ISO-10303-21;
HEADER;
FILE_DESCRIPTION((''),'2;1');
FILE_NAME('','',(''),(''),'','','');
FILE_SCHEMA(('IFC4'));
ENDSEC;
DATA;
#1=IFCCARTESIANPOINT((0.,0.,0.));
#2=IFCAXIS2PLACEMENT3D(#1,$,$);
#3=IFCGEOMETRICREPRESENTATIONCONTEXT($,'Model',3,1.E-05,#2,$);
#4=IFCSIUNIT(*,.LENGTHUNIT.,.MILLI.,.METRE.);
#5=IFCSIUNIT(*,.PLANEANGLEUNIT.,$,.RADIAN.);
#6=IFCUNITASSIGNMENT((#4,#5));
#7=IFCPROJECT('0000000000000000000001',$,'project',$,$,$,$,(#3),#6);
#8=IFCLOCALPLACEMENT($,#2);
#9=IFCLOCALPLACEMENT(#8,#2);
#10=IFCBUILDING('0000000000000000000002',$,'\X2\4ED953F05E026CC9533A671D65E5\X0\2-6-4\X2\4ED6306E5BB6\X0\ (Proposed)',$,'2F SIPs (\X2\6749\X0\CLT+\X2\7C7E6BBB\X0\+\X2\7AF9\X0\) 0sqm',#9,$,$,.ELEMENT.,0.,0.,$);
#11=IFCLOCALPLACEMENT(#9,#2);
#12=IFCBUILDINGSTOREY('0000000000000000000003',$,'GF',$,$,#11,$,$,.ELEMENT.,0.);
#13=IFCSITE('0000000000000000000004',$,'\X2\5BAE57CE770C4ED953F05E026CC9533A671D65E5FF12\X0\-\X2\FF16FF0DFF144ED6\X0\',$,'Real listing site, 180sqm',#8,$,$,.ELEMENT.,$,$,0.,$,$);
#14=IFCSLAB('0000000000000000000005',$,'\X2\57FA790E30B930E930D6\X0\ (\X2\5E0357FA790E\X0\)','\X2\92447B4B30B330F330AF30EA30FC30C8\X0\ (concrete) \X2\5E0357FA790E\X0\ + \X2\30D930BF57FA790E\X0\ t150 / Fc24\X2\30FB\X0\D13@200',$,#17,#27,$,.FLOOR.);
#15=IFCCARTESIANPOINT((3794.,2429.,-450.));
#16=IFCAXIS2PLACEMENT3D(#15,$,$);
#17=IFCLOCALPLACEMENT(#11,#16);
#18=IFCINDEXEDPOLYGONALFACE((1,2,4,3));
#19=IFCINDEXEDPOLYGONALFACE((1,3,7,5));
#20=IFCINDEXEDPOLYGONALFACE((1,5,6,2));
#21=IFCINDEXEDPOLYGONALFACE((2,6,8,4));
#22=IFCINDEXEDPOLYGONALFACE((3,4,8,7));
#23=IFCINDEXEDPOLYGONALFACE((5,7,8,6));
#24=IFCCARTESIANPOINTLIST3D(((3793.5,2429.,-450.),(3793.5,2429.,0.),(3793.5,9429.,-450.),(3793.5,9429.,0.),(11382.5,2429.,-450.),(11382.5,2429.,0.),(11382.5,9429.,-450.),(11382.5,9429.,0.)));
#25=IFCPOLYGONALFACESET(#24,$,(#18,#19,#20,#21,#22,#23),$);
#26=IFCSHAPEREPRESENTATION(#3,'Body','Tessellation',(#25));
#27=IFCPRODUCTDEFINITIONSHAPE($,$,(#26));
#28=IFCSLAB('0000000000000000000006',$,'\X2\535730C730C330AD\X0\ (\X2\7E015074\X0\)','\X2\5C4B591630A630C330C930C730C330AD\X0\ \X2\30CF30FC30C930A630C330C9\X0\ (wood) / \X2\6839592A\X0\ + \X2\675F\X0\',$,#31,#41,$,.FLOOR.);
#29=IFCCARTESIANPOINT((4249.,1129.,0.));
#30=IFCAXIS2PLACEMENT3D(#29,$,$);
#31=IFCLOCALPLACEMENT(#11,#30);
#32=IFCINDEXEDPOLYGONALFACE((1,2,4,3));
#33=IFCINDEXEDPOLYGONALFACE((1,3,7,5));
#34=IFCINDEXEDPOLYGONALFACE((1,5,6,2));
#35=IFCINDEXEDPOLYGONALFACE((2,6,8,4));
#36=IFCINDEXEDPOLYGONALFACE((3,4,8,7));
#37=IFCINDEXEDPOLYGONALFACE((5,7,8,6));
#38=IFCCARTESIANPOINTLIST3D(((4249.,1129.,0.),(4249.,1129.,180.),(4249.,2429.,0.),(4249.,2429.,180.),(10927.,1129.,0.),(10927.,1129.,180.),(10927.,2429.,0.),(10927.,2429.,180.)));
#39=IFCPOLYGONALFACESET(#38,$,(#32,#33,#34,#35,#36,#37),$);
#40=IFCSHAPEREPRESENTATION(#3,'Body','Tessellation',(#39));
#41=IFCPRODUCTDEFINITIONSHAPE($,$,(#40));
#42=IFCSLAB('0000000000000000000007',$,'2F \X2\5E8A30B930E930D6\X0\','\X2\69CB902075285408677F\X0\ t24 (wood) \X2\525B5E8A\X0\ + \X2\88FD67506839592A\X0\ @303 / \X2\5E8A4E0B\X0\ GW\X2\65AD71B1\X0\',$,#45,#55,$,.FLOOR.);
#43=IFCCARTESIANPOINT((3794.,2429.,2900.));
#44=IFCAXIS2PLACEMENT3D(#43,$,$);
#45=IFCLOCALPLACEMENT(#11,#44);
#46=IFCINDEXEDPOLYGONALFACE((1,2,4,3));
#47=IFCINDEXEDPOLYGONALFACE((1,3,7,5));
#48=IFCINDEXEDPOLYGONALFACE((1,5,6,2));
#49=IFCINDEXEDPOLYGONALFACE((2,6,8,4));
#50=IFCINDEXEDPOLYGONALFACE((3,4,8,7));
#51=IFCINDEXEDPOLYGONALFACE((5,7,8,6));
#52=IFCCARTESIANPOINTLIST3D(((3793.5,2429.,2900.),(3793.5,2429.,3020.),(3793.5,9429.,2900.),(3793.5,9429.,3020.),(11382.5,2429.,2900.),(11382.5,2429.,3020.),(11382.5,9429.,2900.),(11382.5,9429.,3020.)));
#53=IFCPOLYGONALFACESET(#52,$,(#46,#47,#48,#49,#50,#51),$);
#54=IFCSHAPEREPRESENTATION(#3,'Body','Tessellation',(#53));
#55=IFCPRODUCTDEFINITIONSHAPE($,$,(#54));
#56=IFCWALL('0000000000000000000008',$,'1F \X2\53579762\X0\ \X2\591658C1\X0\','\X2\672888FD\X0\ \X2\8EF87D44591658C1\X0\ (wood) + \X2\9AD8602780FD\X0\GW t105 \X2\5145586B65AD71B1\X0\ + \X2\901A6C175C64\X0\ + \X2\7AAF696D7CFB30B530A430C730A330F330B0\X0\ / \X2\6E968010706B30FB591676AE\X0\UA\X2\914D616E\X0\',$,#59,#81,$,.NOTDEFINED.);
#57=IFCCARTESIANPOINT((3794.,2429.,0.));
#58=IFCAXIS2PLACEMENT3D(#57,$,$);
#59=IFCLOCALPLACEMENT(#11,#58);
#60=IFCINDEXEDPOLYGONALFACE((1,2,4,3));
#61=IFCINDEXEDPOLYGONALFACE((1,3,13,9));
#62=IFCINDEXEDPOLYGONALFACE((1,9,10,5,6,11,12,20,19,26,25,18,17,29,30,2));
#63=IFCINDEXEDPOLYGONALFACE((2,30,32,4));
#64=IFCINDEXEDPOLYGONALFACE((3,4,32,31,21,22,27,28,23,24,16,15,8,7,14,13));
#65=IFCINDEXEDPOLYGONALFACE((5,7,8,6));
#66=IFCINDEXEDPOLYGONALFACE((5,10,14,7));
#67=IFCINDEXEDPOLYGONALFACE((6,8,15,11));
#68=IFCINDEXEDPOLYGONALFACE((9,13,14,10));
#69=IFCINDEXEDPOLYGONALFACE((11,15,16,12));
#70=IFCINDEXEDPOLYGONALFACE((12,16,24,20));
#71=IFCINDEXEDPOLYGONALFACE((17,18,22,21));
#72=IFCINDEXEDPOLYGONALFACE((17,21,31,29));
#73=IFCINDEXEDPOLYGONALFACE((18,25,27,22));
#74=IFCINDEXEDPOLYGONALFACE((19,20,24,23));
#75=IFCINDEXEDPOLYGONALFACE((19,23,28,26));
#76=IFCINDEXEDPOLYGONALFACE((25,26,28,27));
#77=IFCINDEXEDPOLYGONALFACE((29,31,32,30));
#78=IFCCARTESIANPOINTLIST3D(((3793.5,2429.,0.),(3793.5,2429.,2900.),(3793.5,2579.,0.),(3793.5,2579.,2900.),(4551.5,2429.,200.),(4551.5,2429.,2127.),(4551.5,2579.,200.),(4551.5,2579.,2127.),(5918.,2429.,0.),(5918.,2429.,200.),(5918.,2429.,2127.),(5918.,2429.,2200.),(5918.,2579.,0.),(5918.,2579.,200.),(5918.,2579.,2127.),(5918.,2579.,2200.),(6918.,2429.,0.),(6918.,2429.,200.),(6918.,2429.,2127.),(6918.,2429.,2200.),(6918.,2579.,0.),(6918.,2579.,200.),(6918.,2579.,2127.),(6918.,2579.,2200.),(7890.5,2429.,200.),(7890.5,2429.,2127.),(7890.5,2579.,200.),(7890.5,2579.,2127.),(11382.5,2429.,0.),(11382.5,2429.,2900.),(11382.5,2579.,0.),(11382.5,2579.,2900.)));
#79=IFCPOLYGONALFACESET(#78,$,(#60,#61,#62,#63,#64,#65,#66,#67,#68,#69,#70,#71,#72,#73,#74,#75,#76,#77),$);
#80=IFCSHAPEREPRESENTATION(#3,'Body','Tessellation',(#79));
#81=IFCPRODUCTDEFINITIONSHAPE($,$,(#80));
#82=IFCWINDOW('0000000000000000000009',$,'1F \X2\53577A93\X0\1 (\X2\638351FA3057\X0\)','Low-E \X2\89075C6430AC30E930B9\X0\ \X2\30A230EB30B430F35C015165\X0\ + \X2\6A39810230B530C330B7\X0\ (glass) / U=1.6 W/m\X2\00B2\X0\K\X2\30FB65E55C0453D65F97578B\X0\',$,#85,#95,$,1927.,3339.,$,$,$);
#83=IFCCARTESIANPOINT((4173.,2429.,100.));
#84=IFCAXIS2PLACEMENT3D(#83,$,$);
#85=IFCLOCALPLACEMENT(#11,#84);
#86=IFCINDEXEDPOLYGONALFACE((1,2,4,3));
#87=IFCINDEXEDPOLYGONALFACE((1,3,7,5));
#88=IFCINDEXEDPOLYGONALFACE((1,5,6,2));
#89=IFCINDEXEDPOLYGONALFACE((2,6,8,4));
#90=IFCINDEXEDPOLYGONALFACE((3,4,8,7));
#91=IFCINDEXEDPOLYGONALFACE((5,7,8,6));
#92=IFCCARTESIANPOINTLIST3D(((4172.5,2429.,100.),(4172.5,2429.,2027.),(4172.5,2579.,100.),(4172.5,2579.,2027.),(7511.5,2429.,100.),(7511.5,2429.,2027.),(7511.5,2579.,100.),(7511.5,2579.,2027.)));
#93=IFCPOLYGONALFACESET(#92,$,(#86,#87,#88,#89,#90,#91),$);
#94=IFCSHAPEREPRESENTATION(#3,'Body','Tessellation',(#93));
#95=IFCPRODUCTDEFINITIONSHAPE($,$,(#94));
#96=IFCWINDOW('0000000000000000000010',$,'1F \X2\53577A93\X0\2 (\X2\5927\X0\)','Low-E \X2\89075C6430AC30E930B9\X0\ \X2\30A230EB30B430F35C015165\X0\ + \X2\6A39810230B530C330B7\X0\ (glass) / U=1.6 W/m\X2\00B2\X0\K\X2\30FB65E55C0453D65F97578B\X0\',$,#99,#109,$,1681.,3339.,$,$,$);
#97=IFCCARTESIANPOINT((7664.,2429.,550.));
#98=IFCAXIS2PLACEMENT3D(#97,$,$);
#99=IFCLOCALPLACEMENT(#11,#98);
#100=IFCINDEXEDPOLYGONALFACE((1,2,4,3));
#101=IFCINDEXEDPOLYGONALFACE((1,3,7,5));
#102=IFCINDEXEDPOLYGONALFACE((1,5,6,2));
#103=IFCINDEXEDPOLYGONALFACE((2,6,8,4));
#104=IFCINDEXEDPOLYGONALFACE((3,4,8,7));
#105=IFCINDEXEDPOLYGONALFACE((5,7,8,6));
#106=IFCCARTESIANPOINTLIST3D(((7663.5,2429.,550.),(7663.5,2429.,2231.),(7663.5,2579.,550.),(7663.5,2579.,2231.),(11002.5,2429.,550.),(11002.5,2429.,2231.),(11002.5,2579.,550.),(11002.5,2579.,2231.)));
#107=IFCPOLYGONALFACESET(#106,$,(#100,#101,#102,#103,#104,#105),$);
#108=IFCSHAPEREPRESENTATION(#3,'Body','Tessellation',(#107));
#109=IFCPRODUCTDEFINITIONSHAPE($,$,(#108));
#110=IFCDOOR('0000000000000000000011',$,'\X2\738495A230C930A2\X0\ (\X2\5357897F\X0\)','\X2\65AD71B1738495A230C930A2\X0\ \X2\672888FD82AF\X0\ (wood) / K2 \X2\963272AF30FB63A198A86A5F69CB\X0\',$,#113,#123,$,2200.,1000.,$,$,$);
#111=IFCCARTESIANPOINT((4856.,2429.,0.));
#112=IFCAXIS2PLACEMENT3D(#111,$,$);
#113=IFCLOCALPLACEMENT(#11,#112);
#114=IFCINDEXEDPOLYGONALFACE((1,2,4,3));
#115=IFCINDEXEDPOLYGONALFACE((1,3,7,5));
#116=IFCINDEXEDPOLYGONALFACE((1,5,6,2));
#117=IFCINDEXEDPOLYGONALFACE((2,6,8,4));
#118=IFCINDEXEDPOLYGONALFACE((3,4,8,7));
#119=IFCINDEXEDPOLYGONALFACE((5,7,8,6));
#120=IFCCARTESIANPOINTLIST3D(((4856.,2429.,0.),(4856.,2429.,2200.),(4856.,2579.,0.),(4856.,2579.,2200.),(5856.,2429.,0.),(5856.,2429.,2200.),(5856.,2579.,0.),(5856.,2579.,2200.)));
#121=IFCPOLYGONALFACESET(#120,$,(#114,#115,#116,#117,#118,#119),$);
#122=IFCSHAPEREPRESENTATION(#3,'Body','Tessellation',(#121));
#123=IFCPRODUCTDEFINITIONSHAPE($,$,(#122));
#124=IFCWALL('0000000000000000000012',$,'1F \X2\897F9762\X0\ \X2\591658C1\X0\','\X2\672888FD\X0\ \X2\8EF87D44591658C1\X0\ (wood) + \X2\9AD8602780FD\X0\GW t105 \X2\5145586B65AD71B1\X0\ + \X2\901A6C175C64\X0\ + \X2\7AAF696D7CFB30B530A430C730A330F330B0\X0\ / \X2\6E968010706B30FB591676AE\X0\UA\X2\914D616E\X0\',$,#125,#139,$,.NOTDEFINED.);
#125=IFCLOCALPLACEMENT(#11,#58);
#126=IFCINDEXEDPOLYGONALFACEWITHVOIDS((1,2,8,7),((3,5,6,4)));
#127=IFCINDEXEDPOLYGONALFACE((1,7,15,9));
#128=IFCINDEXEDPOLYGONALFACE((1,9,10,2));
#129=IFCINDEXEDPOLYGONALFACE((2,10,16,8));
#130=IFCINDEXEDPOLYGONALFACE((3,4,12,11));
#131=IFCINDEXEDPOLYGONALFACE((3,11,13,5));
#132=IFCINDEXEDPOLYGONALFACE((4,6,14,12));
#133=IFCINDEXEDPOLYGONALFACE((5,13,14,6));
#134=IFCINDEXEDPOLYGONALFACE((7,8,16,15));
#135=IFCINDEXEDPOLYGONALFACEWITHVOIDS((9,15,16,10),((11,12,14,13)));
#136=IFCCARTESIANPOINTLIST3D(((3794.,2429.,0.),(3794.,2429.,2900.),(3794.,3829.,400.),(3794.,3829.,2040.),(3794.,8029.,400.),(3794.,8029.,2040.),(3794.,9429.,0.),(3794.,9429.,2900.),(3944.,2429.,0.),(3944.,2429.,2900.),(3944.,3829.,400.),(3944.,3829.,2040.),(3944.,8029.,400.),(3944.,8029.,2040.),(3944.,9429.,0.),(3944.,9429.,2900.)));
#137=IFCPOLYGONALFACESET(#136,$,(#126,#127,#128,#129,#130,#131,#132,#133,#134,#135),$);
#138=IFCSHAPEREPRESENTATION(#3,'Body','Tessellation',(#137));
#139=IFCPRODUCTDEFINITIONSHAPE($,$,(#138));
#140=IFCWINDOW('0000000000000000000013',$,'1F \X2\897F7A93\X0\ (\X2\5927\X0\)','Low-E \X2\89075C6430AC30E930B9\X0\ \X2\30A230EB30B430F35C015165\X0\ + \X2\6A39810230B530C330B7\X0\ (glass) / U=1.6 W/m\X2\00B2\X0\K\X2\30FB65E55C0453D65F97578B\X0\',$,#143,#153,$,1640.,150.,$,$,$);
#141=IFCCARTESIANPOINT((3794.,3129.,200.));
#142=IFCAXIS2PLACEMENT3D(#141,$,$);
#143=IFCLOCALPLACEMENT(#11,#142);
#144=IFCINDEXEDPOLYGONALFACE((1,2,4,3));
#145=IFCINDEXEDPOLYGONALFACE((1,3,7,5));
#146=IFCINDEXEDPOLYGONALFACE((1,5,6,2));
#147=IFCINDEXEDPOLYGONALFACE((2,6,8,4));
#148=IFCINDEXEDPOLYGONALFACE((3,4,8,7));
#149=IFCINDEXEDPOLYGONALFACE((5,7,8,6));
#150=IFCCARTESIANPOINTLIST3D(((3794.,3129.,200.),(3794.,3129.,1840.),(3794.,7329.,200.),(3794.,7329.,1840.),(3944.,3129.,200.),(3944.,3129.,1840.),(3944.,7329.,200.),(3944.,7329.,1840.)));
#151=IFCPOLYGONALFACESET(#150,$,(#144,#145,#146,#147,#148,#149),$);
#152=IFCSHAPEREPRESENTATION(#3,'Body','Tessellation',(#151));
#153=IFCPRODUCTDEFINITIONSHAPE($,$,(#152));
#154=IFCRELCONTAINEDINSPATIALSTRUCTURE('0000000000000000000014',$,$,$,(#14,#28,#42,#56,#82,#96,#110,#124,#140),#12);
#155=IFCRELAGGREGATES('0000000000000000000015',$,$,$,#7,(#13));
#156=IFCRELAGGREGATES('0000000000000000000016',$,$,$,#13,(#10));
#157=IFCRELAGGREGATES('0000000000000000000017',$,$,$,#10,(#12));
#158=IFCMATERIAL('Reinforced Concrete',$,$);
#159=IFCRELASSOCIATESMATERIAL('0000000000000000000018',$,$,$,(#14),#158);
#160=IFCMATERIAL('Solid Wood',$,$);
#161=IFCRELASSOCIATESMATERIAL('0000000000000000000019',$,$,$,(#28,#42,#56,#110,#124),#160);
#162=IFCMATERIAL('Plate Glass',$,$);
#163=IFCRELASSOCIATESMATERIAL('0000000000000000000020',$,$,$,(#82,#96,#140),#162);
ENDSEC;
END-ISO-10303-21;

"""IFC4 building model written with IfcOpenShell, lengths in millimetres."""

from ifc_helpers import new_model, si_unit, frame, frame_2d, origin, place, context, project, spatial, rectangle, extrude, material, element, fill, save


model = new_model("IFC4")

# Units and contexts
model_context = context("Model", 3, precision=1e-05, world=origin())
ifc_project = project(units=[si_unit("LENGTHUNIT", "METRE", prefix="MILLI"), si_unit("PLANEANGLEUNIT", "RADIAN")], contexts=[model_context])

# Site, building, storey
site_placement = place(None, origin())
site = spatial("IfcSite", under=ifc_project, at=site_placement, Name="宮城県仙台市泉区朝日２-６－４他", ObjectType="Real listing site, 180sqm", CompositionType="ELEMENT", RefElevation=0.0)
building_placement = place(site_placement, origin())
building = spatial("IfcBuilding", under=site, at=building_placement, Name="仙台市泉区朝日2-6-4他の家 (Proposed)", ObjectType="2F SIPs (杉CLT+籾殻+竹) 0sqm", CompositionType="ELEMENT", ElevationOfRefHeight=0.0, ElevationOfTerrain=0.0)
storey_placement = place(building_placement, origin())
storey = spatial("IfcBuildingStorey", under=building, at=storey_placement, Name="GF", CompositionType="ELEMENT", Elevation=0.0)

# Slabs
ifc_material_1 = material(Name="Reinforced Concrete")
slab_1_placement = place(storey_placement, frame((3794.0, 2429.0, -450.0)))
element("IfcSlab", 1, at=slab_1_placement, inside=storey, material=ifc_material_1, Name="基礎スラブ (布基礎)", Description="鉄筋コンクリート (concrete) 布基礎 + ベタ基礎 t150 / Fc24・D13@200", PredefinedType="FLOOR", context=model_context, shape_type="SweptSolid", body=[
    extrude(rectangle(XDim=7589.0, YDim=7000.0, at=frame_2d((3794.0, 3500.0))), frame((3794.0, 2429.0, -450.0)), (0.0, 0.0, 1.0), 450.0),
])
ifc_material_2 = material(Name="Solid Wood")
slab_2_placement = place(storey_placement, frame((4249.0, 1129.0, 0.0)))
element("IfcSlab", 2, at=slab_2_placement, inside=storey, material=ifc_material_2, Name="南デッキ (縁側)", Description="屋外ウッドデッキ ハードウッド (wood) / 根太 + 束", PredefinedType="FLOOR", context=model_context, shape_type="SweptSolid", body=[
    extrude(rectangle(XDim=6678.0, YDim=1300.0, at=frame_2d((3339.0, 650.0))), frame((4249.0, 1129.0, 0.0)), (0.0, 0.0, 1.0), 180.0),
])
slab_3_placement = place(storey_placement, frame((3794.0, 2429.0, 2900.0)))
element("IfcSlab", 3, at=slab_3_placement, inside=storey, material=ifc_material_2, Name="2F 床スラブ", Description="構造用合板 t24 (wood) 剛床 + 製材根太 @303 / 床下 GW断熱", PredefinedType="FLOOR", context=model_context, shape_type="SweptSolid", body=[
    extrude(rectangle(XDim=7589.0, YDim=7000.0, at=frame_2d((3794.0, 3500.0))), frame((3794.0, 2429.0, 2900.0)), (0.0, 0.0, 1.0), 120.0),
])

# Wall, openings, windows, door
wall_1_placement = place(storey_placement, frame((3794.0, 2429.0, 0.0)))
wall_1 = element("IfcWall", 4, at=wall_1_placement, inside=storey, material=ifc_material_2, Name="1F 南面 外壁", Description="木製 軸組外壁 (wood) + 高性能GW t105 充填断熱 + 通気層 + 窯業系サイディング / 準耐火・外皮UA配慮", PredefinedType="NOTDEFINED", context=model_context, shape_type="SweptSolid", body=[
    extrude(rectangle(XDim=7589.0, YDim=150.0, at=frame_2d((3794.0, 75.0))), frame((3794.0, 2429.0, 0.0)), (0.0, 0.0, 1.0), 2900.0),
])
opening_1_placement = place(storey_placement, frame((4173.0, 2429.0, 100.0)))
opening_1 = element("IfcOpeningElement", 5, at=opening_1_placement, cuts=wall_1, PredefinedType="NOTDEFINED", context=model_context, shape_type="SweptSolid", body=[
    extrude(rectangle(XDim=3339.0, YDim=150.0, at=frame_2d((1669.0, 75.0))), frame((4173.0, 2429.0, 100.0)), (0.0, 0.0, 1.0), 1927.0),
])
opening_2_placement = place(storey_placement, frame((7664.0, 2429.0, 550.0)))
opening_2 = element("IfcOpeningElement", 6, at=opening_2_placement, cuts=wall_1, PredefinedType="NOTDEFINED", context=model_context, shape_type="SweptSolid", body=[
    extrude(rectangle(XDim=3339.0, YDim=150.0, at=frame_2d((1669.0, 75.0))), frame((7664.0, 2429.0, 550.0)), (0.0, 0.0, 1.0), 1681.0),
])
opening_3_placement = place(storey_placement, frame((4856.0, 2429.0, 0.0)))
opening_3 = element("IfcOpeningElement", 7, at=opening_3_placement, cuts=wall_1, PredefinedType="NOTDEFINED", context=model_context, shape_type="SweptSolid", body=[
    extrude(rectangle(XDim=1000.0, YDim=150.0, at=frame_2d((500.0, 75.0))), frame((4856.0, 2429.0, 0.0)), (0.0, 0.0, 1.0), 2200.0),
])
ifc_material_3 = material(Name="Plate Glass")
window_1_placement = place(storey_placement, frame((4173.0, 2429.0, 100.0)))
window_1 = element("IfcWindow", 8, at=window_1_placement, inside=storey, material=ifc_material_3, Name="1F 南窓1 (掃出し)", Description="Low-E 複層ガラス アルゴン封入 + 樹脂サッシ (glass) / U=1.6 W/m²K・日射取得型", OverallHeight=1927.0, OverallWidth=3339.0, context=model_context, shape_type="SweptSolid", body=[
    extrude(rectangle(XDim=3339.0, YDim=150.0, at=frame_2d((1669.0, 75.0))), frame((4173.0, 2429.0, 100.0)), (0.0, 0.0, 1.0), 1927.0),
])
fill(opening_1, window_1)
window_2_placement = place(storey_placement, frame((7664.0, 2429.0, 550.0)))
window_2 = element("IfcWindow", 9, at=window_2_placement, inside=storey, material=ifc_material_3, Name="1F 南窓2 (大)", Description="Low-E 複層ガラス アルゴン封入 + 樹脂サッシ (glass) / U=1.6 W/m²K・日射取得型", OverallHeight=1681.0, OverallWidth=3339.0, context=model_context, shape_type="SweptSolid", body=[
    extrude(rectangle(XDim=3339.0, YDim=150.0, at=frame_2d((1669.0, 75.0))), frame((7664.0, 2429.0, 550.0)), (0.0, 0.0, 1.0), 1681.0),
])
fill(opening_2, window_2)
door_placement = place(storey_placement, frame((4856.0, 2429.0, 0.0)))
door = element("IfcDoor", 10, at=door_placement, inside=storey, material=ifc_material_2, Name="玄関ドア (南西)", Description="断熱玄関ドア 木製芯 (wood) / K2 防犯・採風機構", OverallHeight=2200.0, OverallWidth=1000.0, context=model_context, shape_type="SweptSolid", body=[
    extrude(rectangle(XDim=1000.0, YDim=150.0, at=frame_2d((500.0, 75.0))), frame((4856.0, 2429.0, 0.0)), (0.0, 0.0, 1.0), 2200.0),
])
fill(opening_3, door)

# Wall, opening, window
wall_2_placement = place(storey_placement, frame((3794.0, 2429.0, 0.0)))
wall_2 = element("IfcWall", 11, at=wall_2_placement, inside=storey, material=ifc_material_2, Name="1F 西面 外壁", Description="木製 軸組外壁 (wood) + 高性能GW t105 充填断熱 + 通気層 + 窯業系サイディング / 準耐火・外皮UA配慮", PredefinedType="NOTDEFINED", context=model_context, shape_type="SweptSolid", body=[
    extrude(rectangle(XDim=150.0, YDim=7000.0, at=frame_2d((75.0, 3500.0))), frame((3794.0, 2429.0, 0.0)), (0.0, 0.0, 1.0), 2900.0),
])
opening_4_placement = place(storey_placement, frame((3794.0, 3129.0, 200.0)))
opening_4 = element("IfcOpeningElement", 12, at=opening_4_placement, cuts=wall_2, PredefinedType="NOTDEFINED", context=model_context, shape_type="SweptSolid", body=[
    extrude(rectangle(XDim=150.0, YDim=4200.0, at=frame_2d((75.0, 2100.0))), frame((3794.0, 3129.0, 200.0)), (0.0, 0.0, 1.0), 1640.0),
])
window_3_placement = place(storey_placement, frame((3794.0, 3129.0, 200.0)))
window_3 = element("IfcWindow", 13, at=window_3_placement, inside=storey, material=ifc_material_3, Name="1F 西窓 (大)", Description="Low-E 複層ガラス アルゴン封入 + 樹脂サッシ (glass) / U=1.6 W/m²K・日射取得型", OverallHeight=1640.0, OverallWidth=150.0, context=model_context, shape_type="SweptSolid", body=[
    extrude(rectangle(XDim=150.0, YDim=4200.0, at=frame_2d((75.0, 2100.0))), frame((3794.0, 3129.0, 200.0)), (0.0, 0.0, 1.0), 1640.0),
])
fill(opening_4, window_3)

save(model, "model.ifc")
